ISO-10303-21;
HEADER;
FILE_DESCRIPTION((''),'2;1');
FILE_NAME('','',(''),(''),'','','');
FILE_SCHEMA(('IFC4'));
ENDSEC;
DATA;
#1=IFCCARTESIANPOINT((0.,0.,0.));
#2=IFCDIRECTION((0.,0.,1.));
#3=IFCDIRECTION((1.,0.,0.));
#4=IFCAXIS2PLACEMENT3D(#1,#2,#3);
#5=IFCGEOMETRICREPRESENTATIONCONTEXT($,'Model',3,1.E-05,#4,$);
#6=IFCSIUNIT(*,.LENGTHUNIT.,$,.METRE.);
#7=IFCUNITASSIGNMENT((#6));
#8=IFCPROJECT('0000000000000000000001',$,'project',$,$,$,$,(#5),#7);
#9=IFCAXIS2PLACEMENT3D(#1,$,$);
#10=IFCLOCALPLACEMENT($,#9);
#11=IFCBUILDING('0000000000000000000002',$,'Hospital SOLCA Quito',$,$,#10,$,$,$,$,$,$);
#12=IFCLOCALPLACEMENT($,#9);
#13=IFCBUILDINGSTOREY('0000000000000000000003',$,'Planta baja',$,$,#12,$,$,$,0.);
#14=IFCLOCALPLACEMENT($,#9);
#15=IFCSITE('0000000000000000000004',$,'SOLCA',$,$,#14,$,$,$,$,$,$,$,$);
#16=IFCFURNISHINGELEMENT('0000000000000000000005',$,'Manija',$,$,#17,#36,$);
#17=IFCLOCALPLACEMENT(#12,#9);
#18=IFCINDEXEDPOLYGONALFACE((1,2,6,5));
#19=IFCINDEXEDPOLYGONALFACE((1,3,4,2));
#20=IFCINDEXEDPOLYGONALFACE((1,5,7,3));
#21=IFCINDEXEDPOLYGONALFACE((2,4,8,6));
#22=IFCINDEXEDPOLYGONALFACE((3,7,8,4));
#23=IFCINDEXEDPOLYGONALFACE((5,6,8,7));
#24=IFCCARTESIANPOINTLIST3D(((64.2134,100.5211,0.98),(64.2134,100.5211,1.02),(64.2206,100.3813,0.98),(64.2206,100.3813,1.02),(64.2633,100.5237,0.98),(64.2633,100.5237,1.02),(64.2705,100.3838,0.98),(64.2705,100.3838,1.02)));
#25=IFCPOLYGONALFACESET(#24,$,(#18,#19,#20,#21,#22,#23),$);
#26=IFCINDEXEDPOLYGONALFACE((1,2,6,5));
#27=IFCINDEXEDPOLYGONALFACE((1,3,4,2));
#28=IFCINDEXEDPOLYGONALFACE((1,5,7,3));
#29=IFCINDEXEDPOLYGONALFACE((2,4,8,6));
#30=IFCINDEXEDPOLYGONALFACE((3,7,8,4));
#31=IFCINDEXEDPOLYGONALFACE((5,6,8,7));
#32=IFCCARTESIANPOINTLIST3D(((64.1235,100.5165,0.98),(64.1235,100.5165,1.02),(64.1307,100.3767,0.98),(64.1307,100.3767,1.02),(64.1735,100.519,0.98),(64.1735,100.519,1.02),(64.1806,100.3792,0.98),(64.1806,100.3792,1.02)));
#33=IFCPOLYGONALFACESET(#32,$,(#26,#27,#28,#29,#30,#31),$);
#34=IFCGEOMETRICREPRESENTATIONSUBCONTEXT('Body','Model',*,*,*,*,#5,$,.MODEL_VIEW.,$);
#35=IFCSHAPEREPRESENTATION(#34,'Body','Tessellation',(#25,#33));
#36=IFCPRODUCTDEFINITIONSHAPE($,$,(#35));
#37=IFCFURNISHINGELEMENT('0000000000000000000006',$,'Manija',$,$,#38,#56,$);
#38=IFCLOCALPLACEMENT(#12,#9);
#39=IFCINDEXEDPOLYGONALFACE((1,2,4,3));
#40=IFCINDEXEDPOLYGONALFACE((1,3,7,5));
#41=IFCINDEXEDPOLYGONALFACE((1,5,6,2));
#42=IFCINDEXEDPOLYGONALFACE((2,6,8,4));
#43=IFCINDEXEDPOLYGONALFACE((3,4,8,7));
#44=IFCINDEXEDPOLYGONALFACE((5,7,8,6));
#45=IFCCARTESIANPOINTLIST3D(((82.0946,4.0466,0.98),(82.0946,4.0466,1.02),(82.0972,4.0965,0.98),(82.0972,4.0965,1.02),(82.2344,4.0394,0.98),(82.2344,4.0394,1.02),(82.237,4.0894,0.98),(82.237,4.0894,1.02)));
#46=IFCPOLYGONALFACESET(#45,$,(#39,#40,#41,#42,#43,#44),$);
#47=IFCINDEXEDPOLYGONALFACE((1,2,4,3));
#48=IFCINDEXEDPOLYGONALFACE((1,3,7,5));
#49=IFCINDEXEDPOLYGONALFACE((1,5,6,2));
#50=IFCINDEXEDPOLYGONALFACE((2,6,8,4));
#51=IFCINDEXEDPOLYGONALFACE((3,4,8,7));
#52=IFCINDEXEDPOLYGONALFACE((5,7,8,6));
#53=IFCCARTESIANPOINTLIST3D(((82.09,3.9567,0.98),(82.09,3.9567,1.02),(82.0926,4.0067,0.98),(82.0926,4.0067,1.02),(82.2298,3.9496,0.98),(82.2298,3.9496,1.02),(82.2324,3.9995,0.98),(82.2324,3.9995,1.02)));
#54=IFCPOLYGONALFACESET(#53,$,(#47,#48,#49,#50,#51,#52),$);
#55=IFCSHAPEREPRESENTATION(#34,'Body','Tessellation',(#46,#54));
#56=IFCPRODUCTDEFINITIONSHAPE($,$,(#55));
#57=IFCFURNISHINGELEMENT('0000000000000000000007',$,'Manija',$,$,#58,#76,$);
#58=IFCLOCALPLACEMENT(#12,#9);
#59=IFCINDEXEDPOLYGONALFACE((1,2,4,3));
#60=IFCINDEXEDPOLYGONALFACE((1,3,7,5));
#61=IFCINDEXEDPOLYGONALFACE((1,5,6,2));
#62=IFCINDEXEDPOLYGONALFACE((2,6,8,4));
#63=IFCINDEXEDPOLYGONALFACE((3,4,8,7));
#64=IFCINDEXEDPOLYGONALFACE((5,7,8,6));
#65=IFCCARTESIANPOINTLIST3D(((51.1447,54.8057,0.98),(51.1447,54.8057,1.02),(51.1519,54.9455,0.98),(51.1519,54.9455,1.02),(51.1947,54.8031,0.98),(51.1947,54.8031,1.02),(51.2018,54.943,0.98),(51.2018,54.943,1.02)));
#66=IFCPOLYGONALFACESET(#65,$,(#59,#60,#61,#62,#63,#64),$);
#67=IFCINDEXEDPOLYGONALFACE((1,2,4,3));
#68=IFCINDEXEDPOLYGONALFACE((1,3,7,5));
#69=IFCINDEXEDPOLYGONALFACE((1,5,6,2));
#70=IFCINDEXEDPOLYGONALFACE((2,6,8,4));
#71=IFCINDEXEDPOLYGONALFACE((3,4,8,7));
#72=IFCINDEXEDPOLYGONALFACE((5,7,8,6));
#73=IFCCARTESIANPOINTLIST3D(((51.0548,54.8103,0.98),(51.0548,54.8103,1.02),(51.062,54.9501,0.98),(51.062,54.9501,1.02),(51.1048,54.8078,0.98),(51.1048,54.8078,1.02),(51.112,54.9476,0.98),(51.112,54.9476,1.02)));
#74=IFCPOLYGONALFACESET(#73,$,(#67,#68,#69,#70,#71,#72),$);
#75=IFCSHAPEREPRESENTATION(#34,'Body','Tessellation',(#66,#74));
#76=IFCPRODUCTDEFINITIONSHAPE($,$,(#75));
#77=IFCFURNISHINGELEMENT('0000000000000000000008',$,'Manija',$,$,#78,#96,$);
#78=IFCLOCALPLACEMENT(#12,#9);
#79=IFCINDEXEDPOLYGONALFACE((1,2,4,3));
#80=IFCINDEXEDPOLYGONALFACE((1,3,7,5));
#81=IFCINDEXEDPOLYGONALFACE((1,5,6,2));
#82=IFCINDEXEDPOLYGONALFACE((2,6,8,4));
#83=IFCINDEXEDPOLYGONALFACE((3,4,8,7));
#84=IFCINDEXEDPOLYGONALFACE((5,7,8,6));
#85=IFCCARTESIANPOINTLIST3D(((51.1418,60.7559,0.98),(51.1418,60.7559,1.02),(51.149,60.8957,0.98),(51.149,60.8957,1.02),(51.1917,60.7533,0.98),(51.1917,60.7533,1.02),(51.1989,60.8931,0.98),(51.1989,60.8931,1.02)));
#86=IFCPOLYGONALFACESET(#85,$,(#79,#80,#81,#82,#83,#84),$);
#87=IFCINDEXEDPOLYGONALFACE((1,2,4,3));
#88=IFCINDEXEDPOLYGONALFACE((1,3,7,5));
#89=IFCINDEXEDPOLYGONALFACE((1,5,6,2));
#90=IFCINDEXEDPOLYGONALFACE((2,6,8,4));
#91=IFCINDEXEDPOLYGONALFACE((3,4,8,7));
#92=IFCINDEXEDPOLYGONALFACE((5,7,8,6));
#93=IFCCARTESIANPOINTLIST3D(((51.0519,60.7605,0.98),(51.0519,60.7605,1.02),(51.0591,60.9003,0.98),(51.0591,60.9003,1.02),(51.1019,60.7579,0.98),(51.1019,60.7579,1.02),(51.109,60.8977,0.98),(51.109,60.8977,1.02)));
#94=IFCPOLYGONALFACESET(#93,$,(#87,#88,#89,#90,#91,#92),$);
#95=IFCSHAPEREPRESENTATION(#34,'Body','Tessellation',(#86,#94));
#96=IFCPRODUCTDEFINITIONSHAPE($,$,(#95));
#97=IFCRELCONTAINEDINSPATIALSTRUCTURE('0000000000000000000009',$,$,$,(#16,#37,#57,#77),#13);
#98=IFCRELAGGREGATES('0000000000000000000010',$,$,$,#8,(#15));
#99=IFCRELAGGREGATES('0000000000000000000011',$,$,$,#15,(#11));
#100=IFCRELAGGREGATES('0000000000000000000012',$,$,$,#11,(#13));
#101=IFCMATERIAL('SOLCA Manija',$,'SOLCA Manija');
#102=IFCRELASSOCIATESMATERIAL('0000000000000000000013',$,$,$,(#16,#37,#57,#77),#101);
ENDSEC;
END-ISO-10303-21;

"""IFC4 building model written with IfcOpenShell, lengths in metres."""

from ifc_helpers import new_model, si_unit, frame, origin, origin_with_axes, place, context, subcontext, project, spatial, polyline, outline, extrude, material, element, save


model = new_model("IFC4")

# Units and contexts
model_context = context("Model", 3, precision=1e-05, world=origin_with_axes())
body_context = subcontext(model_context, "Body", "Model", "MODEL_VIEW")
ifc_project = project(units=[si_unit("LENGTHUNIT", "METRE")], contexts=[model_context])

# Site, building, storey
site_placement = place(None, origin())
site = spatial("IfcSite", under=ifc_project, at=site_placement, Name="SOLCA")
building_placement = place(None, origin())
building = spatial("IfcBuilding", under=site, at=building_placement, Name="Hospital SOLCA Quito")
storey_placement = place(None, origin())
storey = spatial("IfcBuildingStorey", under=building, at=storey_placement, Name="Planta baja", Elevation=0.0)

# Furnishing elements
ifc_material_1 = material(Name="SOLCA Manija", Category="SOLCA Manija")
furnishing_1_placement = place(storey_placement, origin_with_axes())
element("IfcFurnishingElement", 1, at=furnishing_1_placement, inside=storey, material=ifc_material_1, Name="Manija", context=body_context, shape_type="SweptSolid", body=[
    extrude(outline(polyline([(64.2705, 100.3838), (64.2633, 100.5237), (64.2134, 100.5211), (64.2206, 100.3813), (64.2705, 100.3838)])), frame((0.0, 0.0, 0.98), z_axis=(0.0, 0.0, 1.0), x_axis=(1.0, 0.0, 0.0)), (0.0, 0.0, 1.0), 0.04),
    extrude(outline(polyline([(64.1806, 100.3792), (64.1735, 100.519), (64.1235, 100.5165), (64.1307, 100.3767), (64.1806, 100.3792)])), frame((0.0, 0.0, 0.98), z_axis=(0.0, 0.0, 1.0), x_axis=(1.0, 0.0, 0.0)), (0.0, 0.0, 1.0), 0.04),
])
furnishing_2_placement = place(storey_placement, origin_with_axes())
element("IfcFurnishingElement", 2, at=furnishing_2_placement, inside=storey, material=ifc_material_1, Name="Manija", context=body_context, shape_type="SweptSolid", body=[
    extrude(outline(polyline([(82.237, 4.0894), (82.0972, 4.0965), (82.0946, 4.0466), (82.2344, 4.0394), (82.237, 4.0894)])), frame((0.0, 0.0, 0.98), z_axis=(0.0, 0.0, 1.0), x_axis=(1.0, 0.0, 0.0)), (0.0, 0.0, 1.0), 0.04),
    extrude(outline(polyline([(82.2324, 3.9995), (82.0926, 4.0067), (82.09, 3.9567), (82.2298, 3.9496), (82.2324, 3.9995)])), frame((0.0, 0.0, 0.98), z_axis=(0.0, 0.0, 1.0), x_axis=(1.0, 0.0, 0.0)), (0.0, 0.0, 1.0), 0.04),
])
furnishing_3_placement = place(storey_placement, origin_with_axes())
element("IfcFurnishingElement", 3, at=furnishing_3_placement, inside=storey, material=ifc_material_1, Name="Manija", context=body_context, shape_type="SweptSolid", body=[
    extrude(outline(polyline([(51.1947, 54.8031), (51.2018, 54.943), (51.1519, 54.9455), (51.1447, 54.8057), (51.1947, 54.8031)])), frame((0.0, 0.0, 0.98), z_axis=(0.0, 0.0, 1.0), x_axis=(1.0, 0.0, 0.0)), (0.0, 0.0, 1.0), 0.04),
    extrude(outline(polyline([(51.1048, 54.8078), (51.112, 54.9476), (51.062, 54.9501), (51.0548, 54.8103), (51.1048, 54.8078)])), frame((0.0, 0.0, 0.98), z_axis=(0.0, 0.0, 1.0), x_axis=(1.0, 0.0, 0.0)), (0.0, 0.0, 1.0), 0.04),
])
furnishing_4_placement = place(storey_placement, origin_with_axes())
element("IfcFurnishingElement", 4, at=furnishing_4_placement, inside=storey, material=ifc_material_1, Name="Manija", context=body_context, shape_type="SweptSolid", body=[
    extrude(outline(polyline([(51.1917, 60.7533), (51.1989, 60.8931), (51.149, 60.8957), (51.1418, 60.7559), (51.1917, 60.7533)])), frame((0.0, 0.0, 0.98), z_axis=(0.0, 0.0, 1.0), x_axis=(1.0, 0.0, 0.0)), (0.0, 0.0, 1.0), 0.04),
    extrude(outline(polyline([(51.1019, 60.7579), (51.109, 60.8977), (51.0591, 60.9003), (51.0519, 60.7605), (51.1019, 60.7579)])), frame((0.0, 0.0, 0.98), z_axis=(0.0, 0.0, 1.0), x_axis=(1.0, 0.0, 0.0)), (0.0, 0.0, 1.0), 0.04),
])

save(model, "model.ifc")
